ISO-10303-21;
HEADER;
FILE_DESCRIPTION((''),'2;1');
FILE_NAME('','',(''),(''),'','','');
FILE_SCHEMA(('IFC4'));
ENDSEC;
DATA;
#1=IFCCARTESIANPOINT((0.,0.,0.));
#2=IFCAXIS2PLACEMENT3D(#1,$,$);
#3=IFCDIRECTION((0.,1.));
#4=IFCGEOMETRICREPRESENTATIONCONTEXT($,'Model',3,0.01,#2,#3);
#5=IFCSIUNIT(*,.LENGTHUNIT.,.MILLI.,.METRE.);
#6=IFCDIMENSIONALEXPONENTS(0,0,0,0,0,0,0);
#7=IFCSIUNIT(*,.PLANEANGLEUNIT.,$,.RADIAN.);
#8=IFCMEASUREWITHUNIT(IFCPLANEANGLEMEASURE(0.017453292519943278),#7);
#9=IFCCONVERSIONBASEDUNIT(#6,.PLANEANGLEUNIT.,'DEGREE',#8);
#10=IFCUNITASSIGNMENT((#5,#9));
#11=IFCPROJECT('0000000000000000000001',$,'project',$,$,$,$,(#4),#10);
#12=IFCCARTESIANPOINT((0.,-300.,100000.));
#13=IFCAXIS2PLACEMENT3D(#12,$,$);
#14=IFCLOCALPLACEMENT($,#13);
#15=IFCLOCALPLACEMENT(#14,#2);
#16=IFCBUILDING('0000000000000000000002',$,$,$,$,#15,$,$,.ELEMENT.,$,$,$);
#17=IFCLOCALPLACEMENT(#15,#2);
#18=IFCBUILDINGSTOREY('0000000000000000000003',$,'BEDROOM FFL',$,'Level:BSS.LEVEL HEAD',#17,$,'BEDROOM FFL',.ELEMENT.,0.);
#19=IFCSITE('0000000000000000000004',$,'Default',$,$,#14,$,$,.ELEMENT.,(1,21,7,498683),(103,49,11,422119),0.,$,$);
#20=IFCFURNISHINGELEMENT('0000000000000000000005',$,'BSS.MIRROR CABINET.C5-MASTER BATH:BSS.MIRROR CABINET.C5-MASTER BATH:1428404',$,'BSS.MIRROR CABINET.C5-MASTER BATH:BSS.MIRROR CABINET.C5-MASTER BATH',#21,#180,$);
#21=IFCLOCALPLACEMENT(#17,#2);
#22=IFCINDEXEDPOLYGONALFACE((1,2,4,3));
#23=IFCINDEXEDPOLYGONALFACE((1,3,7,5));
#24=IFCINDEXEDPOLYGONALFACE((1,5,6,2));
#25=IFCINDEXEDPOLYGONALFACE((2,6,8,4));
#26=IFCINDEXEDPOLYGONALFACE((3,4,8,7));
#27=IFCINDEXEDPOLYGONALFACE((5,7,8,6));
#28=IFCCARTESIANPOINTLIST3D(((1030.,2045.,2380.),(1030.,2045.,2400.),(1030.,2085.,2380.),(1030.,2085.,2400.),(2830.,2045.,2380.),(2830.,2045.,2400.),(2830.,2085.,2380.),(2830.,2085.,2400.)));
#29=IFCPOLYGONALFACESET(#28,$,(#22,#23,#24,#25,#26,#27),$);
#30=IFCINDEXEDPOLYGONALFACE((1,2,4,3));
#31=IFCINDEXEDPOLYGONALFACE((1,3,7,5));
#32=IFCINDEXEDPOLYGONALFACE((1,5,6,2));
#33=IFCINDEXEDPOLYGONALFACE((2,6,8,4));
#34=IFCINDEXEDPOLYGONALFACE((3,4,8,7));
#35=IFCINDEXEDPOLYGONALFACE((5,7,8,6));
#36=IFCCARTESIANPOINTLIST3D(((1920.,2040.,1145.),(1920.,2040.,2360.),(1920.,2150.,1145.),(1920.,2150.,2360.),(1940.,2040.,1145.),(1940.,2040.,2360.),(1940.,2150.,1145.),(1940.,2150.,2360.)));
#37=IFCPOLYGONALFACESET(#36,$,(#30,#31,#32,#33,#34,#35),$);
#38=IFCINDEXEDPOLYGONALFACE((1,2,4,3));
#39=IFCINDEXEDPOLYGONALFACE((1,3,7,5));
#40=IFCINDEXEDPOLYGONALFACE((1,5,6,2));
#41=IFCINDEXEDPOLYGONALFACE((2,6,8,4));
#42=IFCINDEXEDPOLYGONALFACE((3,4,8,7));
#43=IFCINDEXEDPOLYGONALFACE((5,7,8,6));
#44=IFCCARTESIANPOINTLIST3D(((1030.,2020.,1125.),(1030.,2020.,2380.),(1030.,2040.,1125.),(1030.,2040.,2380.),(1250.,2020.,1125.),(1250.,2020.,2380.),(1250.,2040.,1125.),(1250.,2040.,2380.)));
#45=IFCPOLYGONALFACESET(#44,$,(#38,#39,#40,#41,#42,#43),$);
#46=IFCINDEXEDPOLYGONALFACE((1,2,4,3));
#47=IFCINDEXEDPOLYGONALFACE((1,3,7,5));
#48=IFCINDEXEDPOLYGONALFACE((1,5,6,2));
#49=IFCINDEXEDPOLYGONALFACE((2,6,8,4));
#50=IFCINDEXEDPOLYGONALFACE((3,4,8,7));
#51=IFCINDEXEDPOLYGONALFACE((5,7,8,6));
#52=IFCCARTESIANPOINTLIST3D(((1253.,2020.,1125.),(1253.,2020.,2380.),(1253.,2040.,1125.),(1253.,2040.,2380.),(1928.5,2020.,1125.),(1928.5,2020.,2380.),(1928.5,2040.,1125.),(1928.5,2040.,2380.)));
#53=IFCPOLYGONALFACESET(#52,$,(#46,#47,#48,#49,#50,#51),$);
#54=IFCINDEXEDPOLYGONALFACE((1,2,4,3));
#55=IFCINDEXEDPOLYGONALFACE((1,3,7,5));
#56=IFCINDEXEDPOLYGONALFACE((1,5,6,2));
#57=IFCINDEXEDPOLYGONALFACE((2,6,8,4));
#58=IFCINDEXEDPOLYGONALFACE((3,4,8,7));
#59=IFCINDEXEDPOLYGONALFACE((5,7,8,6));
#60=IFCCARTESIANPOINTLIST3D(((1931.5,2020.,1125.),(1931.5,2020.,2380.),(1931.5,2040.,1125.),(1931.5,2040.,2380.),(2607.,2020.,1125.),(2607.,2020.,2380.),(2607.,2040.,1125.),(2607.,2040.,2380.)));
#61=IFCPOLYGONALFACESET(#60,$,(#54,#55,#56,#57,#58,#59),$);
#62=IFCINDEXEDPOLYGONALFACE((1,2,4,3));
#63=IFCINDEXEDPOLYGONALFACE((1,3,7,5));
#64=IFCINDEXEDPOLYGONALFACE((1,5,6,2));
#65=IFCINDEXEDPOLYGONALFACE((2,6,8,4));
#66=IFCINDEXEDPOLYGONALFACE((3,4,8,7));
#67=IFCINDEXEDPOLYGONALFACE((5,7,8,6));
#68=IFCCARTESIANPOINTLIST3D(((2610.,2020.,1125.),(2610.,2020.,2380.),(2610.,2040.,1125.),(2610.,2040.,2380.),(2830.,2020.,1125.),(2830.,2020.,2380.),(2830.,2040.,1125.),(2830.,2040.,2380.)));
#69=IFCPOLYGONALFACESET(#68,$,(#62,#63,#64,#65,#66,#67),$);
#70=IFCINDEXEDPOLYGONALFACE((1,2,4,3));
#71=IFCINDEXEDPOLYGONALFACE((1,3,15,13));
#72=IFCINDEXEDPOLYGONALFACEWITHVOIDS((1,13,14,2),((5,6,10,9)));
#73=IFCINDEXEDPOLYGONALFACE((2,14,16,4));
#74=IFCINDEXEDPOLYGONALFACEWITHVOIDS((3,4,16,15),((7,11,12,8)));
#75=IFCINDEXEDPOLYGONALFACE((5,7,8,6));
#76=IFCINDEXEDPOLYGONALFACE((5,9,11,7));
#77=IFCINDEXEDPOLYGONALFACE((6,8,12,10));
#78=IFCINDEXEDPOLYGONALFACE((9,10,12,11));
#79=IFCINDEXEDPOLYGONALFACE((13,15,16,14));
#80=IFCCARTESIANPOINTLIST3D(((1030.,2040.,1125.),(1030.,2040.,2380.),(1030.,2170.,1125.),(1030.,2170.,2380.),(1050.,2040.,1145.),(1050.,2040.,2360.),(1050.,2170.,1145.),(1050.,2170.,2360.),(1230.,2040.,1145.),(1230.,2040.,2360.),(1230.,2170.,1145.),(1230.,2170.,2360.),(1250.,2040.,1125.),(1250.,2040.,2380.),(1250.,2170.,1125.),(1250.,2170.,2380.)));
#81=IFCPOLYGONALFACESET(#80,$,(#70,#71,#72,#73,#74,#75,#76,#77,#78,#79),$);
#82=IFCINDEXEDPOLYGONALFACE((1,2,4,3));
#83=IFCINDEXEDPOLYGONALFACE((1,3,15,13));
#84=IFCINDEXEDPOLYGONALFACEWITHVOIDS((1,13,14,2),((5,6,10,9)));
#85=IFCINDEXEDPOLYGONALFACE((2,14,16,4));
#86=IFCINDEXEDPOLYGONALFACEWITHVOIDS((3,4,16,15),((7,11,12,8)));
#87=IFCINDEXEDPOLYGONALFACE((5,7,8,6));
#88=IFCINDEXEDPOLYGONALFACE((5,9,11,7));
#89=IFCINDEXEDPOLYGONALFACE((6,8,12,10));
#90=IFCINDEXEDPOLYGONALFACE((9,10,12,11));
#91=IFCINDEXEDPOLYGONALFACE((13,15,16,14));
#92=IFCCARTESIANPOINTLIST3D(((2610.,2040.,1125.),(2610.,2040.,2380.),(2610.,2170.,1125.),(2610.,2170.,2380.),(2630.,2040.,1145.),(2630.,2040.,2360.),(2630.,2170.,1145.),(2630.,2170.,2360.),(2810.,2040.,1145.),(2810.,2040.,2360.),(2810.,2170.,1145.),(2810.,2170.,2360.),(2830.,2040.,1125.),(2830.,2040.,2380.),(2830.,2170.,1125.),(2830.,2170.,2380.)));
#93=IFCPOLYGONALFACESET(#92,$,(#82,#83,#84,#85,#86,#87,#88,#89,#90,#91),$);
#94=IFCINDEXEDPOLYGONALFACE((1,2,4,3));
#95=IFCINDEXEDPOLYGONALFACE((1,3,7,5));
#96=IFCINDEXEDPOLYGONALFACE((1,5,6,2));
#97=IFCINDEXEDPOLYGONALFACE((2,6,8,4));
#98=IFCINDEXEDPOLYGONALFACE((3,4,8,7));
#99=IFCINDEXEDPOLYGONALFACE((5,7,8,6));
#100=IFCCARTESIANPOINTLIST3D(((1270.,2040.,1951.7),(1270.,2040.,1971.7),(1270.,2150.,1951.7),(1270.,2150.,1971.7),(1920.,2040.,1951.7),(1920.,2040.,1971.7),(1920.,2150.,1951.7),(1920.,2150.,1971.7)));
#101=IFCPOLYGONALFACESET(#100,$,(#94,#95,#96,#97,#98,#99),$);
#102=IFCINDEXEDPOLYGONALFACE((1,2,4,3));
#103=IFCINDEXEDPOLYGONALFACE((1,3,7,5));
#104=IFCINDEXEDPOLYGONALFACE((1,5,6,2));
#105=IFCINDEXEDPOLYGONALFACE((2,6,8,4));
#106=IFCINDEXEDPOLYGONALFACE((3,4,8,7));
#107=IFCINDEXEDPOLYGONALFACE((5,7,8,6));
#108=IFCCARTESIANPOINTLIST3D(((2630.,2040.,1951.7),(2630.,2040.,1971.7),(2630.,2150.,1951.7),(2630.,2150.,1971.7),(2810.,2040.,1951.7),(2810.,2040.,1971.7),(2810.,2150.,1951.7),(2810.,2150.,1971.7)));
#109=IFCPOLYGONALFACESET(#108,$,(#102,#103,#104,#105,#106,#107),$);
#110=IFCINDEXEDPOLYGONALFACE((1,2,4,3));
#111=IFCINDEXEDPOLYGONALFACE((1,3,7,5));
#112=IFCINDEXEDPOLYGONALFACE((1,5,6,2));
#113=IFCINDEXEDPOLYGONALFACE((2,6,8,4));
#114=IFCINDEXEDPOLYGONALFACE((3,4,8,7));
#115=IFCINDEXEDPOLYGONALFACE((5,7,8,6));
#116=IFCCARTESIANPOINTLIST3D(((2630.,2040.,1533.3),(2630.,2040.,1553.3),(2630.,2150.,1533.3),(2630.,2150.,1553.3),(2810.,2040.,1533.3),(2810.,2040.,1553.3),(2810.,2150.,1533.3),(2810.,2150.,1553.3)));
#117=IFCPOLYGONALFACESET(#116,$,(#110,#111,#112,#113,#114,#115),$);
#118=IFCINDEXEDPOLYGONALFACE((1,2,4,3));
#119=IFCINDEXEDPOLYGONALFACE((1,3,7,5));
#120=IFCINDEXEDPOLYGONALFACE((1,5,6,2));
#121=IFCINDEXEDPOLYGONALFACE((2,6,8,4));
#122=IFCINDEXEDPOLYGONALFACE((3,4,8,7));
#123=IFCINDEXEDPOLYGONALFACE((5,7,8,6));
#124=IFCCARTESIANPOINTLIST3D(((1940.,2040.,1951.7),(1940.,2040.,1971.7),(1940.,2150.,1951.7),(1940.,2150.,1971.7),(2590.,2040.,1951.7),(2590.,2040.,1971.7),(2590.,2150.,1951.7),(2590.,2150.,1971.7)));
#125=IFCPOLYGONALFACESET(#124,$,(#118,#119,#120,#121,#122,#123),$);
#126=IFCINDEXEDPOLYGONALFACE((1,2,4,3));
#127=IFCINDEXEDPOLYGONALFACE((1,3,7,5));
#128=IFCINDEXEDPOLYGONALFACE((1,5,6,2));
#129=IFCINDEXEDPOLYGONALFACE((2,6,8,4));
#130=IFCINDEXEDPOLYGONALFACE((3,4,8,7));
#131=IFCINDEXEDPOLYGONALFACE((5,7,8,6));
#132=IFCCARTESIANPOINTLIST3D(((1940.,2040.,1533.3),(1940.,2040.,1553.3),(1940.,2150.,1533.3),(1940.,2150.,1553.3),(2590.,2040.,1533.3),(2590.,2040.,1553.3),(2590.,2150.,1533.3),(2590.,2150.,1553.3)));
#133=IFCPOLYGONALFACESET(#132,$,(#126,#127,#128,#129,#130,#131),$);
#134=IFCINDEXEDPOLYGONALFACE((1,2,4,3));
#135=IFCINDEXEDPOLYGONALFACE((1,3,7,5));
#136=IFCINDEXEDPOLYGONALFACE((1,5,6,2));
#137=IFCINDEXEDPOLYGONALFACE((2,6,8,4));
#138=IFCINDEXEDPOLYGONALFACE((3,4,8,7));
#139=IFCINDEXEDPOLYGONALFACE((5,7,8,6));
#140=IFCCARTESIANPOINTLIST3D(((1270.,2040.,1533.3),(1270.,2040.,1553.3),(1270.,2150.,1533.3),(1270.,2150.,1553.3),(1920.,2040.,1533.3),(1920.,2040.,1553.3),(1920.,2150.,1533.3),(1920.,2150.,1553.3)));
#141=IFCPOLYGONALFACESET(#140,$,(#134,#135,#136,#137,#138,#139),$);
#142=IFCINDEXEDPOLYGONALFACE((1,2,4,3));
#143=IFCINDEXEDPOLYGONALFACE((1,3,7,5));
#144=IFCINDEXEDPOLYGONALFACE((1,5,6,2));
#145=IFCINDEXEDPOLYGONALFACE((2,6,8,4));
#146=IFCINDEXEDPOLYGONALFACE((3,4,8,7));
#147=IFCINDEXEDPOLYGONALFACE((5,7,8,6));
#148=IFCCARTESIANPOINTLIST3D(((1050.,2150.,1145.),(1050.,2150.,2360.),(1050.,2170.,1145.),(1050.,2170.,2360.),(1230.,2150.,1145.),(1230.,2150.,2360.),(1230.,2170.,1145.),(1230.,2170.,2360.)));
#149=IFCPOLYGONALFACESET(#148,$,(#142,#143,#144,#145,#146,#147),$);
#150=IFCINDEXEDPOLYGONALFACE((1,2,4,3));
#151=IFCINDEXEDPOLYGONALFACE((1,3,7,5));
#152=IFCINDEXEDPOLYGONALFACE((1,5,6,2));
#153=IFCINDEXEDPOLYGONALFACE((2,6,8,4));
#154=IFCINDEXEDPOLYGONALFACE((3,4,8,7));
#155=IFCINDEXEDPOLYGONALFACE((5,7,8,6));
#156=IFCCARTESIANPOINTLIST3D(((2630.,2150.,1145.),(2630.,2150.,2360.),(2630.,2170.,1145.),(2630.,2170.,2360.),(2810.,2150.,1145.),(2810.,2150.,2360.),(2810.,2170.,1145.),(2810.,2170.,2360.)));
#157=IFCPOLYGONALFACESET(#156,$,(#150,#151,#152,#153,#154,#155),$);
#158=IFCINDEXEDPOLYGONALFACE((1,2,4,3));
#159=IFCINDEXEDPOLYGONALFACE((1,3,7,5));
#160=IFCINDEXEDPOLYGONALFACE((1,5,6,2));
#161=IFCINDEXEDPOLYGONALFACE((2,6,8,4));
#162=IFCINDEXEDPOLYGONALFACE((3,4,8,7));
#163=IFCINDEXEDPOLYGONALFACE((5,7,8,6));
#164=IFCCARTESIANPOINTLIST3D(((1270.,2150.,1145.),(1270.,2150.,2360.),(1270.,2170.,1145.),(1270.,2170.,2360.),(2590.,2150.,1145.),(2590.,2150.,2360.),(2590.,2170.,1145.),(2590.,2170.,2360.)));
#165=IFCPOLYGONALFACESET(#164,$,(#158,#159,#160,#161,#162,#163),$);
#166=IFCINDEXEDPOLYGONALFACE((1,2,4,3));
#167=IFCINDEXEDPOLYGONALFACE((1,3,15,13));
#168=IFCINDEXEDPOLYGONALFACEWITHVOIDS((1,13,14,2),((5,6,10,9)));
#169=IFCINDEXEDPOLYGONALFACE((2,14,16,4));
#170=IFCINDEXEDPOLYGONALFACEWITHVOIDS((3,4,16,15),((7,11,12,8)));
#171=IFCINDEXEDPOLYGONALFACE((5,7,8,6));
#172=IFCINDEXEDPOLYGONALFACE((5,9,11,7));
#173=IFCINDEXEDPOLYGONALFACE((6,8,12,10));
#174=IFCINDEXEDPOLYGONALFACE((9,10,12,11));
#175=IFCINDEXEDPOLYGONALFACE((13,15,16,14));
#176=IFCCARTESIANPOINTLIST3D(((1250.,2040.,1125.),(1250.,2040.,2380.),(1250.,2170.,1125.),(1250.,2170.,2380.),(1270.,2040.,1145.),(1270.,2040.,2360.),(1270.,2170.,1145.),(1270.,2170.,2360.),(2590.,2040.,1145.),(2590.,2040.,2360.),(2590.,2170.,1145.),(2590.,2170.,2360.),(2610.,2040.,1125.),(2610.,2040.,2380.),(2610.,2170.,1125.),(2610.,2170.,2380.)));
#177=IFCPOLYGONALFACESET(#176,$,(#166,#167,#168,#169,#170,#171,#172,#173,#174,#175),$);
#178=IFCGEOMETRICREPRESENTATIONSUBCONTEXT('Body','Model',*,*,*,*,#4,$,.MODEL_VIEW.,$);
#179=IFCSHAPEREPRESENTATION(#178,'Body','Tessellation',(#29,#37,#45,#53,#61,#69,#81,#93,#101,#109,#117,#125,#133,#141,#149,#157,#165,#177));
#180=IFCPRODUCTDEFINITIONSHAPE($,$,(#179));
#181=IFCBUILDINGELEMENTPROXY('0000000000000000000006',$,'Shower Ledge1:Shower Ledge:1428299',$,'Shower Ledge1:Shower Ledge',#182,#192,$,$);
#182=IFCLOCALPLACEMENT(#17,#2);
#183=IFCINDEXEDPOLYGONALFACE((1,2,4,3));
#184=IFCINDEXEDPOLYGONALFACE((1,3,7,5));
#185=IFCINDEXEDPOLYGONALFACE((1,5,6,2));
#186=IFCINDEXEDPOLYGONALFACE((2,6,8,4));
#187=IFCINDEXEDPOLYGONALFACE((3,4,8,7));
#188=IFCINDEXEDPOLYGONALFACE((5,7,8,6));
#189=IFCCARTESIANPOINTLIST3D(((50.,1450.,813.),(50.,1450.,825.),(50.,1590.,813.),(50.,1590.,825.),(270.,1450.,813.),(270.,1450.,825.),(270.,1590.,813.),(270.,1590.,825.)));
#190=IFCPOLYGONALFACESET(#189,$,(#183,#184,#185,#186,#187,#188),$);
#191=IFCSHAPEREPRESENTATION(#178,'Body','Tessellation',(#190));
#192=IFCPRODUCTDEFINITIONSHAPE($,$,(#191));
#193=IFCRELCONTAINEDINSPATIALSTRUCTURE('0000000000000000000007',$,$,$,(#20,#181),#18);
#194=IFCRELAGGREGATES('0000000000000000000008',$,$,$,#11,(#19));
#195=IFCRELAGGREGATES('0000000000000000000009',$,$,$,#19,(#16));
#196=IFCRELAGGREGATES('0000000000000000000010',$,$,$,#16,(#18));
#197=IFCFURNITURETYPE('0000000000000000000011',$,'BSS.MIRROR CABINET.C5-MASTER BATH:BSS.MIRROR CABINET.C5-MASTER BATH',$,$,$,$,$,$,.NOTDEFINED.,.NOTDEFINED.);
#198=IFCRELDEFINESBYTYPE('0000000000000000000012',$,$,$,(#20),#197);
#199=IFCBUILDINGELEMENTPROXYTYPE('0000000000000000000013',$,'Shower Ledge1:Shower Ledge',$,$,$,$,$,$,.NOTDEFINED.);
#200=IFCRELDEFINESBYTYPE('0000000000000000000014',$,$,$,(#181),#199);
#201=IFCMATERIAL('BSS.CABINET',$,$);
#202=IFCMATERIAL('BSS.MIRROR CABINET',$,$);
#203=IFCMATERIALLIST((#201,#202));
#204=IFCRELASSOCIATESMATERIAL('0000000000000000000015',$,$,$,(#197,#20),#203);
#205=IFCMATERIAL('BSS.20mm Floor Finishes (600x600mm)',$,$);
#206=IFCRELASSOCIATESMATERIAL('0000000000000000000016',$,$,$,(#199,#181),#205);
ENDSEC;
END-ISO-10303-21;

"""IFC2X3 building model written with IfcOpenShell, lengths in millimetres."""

from ifc_helpers import new_model, entity, si_unit, converted_unit, direction, frame, frame_2d, origin, origin_2d_with_axis, place, context, subcontext, project, spatial, polyline, rectangle, outline, extrude, source, transform, mapped, material, material_list, type_object, type_shapes, element, save


model = new_model("IFC2X3")

# Units and contexts
model_context = context("Model", 3, precision=0.01, world=origin(), true_north=direction((0.0, 1.0)))
body_context = subcontext(model_context, "Body", "Model", "MODEL_VIEW")
ifc_project = project(units=[si_unit("LENGTHUNIT", "METRE", prefix="MILLI"), converted_unit("PLANEANGLEUNIT", "DEGREE", entity("IfcPlaneAngleMeasure", 0.017453292519943278), si_unit("PLANEANGLEUNIT", "RADIAN"), dimensions=[0, 0, 0, 0, 0, 0, 0])], contexts=[model_context])

# Site, building, storey
site_placement = place(None, frame((0.0, -300.0, 100000.0)))
site = spatial("IfcSite", under=ifc_project, at=site_placement, Name="Default", CompositionType="ELEMENT", RefLatitude=(1, 21, 7, 498683), RefLongitude=(103, 49, 11, 422119), RefElevation=0.0)
building_placement = place(site_placement, origin())
building = spatial("IfcBuilding", under=site, at=building_placement, CompositionType="ELEMENT")
storey_placement = place(building_placement, origin())
storey = spatial("IfcBuildingStorey", under=building, at=storey_placement, Name="BEDROOM FFL", ObjectType="Level:BSS.LEVEL HEAD", LongName="BEDROOM FFL", CompositionType="ELEMENT", Elevation=0.0)

# Furnishing element
ifc_material_1 = material(Name="BSS.CABINET")
ifc_material_2 = material(Name="BSS.MIRROR CABINET")
ifc_material_list = material_list([ifc_material_1, ifc_material_2])
furniture_type = type_object("IfcFurnitureType", Name="BSS.MIRROR CABINET.C5-MASTER BATH:BSS.MIRROR CABINET.C5-MASTER BATH", AssemblyPlace="NOTDEFINED", material=ifc_material_list)
shared_shape_1 = source(origin(), body_context, "Body", "SweptSolid", [
    extrude(rectangle(XDim=40.0, YDim=1800.0, at=frame_2d((0.0, 0.0), x_axis=(1.0, 0.0))), frame((0.0, 105.0, 1255.0), z_axis=(0.0, 0.0, 1.0), x_axis=(0.0, 1.0, 0.0)), (0.0, 0.0, 1.0), 20.0),
    extrude(rectangle(XDim=20.0, YDim=110.0, at=frame_2d((0.0, 0.0), x_axis=(1.0, 0.0))), frame((0.0, 75.0, 20.0), z_axis=(0.0, 0.0, 1.0), x_axis=(-1.0, 0.0, 0.0)), (0.0, 0.0, 1.0), 1215.0),
    extrude(rectangle(XDim=220.0, YDim=20.0, at=frame_2d((0.0, 0.0), x_axis=(1.0, 0.0))), frame((790.0, 140.0, 0.0), z_axis=(0.0, 0.0, 1.0), x_axis=(-1.0, 0.0, 0.0)), (0.0, 0.0, 1.0), 1255.0),
    extrude(rectangle(XDim=675.5, YDim=20.0, at=frame_2d((0.0, 0.0), x_axis=(1.0, 0.0))), frame((339.2, 140.0, 0.0), z_axis=(0.0, 0.0, 1.0), x_axis=(-1.0, 0.0, 0.0)), (0.0, 0.0, 1.0), 1255.0),
    extrude(rectangle(XDim=675.5, YDim=20.0, at=frame_2d((0.0, 0.0), x_axis=(1.0, 0.0))), frame((-339.3, 140.0, 0.0), z_axis=(0.0, 0.0, 1.0), x_axis=(-1.0, 0.0, 0.0)), (0.0, 0.0, 1.0), 1255.0),
    extrude(rectangle(XDim=220.0, YDim=20.0, at=frame_2d((0.0, 0.0), x_axis=(1.0, 0.0))), frame((-790.0, 140.0, 0.0), z_axis=(0.0, 0.0, 1.0), x_axis=(-1.0, 0.0, 0.0)), (0.0, 0.0, 1.0), 1255.0),
    extrude(outline(polyline([(-627.5, -110.0), (627.5, -110.0), (627.5, 110.0), (-627.5, 110.0), (-627.5, -110.0)]), holes=[polyline([(607.5, 90.0), (607.5, -90.0), (-607.5, -90.0), (-607.5, 90.0), (607.5, 90.0)])]), frame((790.0, 0.0, 627.5), z_axis=(0.0, 1.0, 0.0), x_axis=(0.0, 0.0, -1.0)), (0.0, 0.0, 1.0), 130.0),
    extrude(outline(polyline([(-627.5, -110.0), (627.5, -110.0), (627.5, 110.0), (-627.5, 110.0), (-627.5, -110.0)]), holes=[polyline([(607.5, 90.0), (607.5, -90.0), (-607.5, -90.0), (-607.5, 90.0), (607.5, 90.0)])]), frame((-790.0, 0.0, 627.5), z_axis=(0.0, 1.0, 0.0), x_axis=(0.0, 0.0, -1.0)), (0.0, 0.0, 1.0), 130.0),
    extrude(rectangle(XDim=650.0, YDim=110.0, at=origin_2d_with_axis()), frame((335.0, 75.0, 826.7), z_axis=(0.0, 0.0, 1.0), x_axis=(-1.0, 0.0, 0.0)), (0.0, 0.0, 1.0), 20.0),
    extrude(rectangle(XDim=180.0, YDim=110.0, at=origin_2d_with_axis()), frame((-790.0, 75.0, 826.7), z_axis=(0.0, 0.0, 1.0), x_axis=(-1.0, 0.0, 0.0)), (0.0, 0.0, 1.0), 20.0),
    extrude(rectangle(XDim=180.0, YDim=110.0, at=origin_2d_with_axis()), frame((-790.0, 75.0, 408.3), z_axis=(0.0, 0.0, 1.0), x_axis=(-1.0, 0.0, 0.0)), (0.0, 0.0, 1.0), 20.0),
    extrude(rectangle(XDim=650.0, YDim=110.0, at=origin_2d_with_axis()), frame((-335.0, 75.0, 826.7), z_axis=(0.0, 0.0, 1.0), x_axis=(-1.0, 0.0, 0.0)), (0.0, 0.0, 1.0), 20.0),
    extrude(rectangle(XDim=650.0, YDim=110.0, at=frame_2d((0.0, 0.0), x_axis=(1.0, 0.0))), frame((-335.0, 75.0, 408.3), z_axis=(0.0, 0.0, 1.0), x_axis=(-1.0, 0.0, 0.0)), (0.0, 0.0, 1.0), 20.0),
    extrude(rectangle(XDim=650.0, YDim=110.0, at=origin_2d_with_axis()), frame((335.0, 75.0, 408.3), z_axis=(0.0, 0.0, 1.0), x_axis=(-1.0, 0.0, 0.0)), (0.0, 0.0, 1.0), 20.0),
    extrude(rectangle(XDim=180.0, YDim=20.0, at=origin_2d_with_axis()), frame((790.0, 10.0, 20.0), z_axis=(0.0, 0.0, 1.0), x_axis=(-1.0, 0.0, 0.0)), (0.0, 0.0, 1.0), 1215.0),
    extrude(rectangle(XDim=180.0, YDim=20.0, at=origin_2d_with_axis()), frame((-790.0, 10.0, 20.0), z_axis=(0.0, 0.0, 1.0), x_axis=(-1.0, 0.0, 0.0)), (0.0, 0.0, 1.0), 1215.0),
    extrude(rectangle(XDim=1320.0, YDim=20.0, at=origin_2d_with_axis()), frame((0.0, 10.0, 20.0), z_axis=(0.0, 0.0, 1.0), x_axis=(-1.0, 0.0, 0.0)), (0.0, 0.0, 1.0), 1215.0),
    extrude(outline(polyline([(-680.0, -627.5), (680.0, -627.5), (680.0, 627.5), (-680.0, 627.5), (-680.0, -627.5)]), holes=[polyline([(660.0, 607.5), (660.0, -607.5), (-660.0, -607.5), (-660.0, 607.5), (660.0, 607.5)])]), frame((0.0, 0.0, 627.5), z_axis=(0.0, 1.0, 0.0), x_axis=(-1.0, 0.0, 0.0)), (0.0, 0.0, 1.0), 130.0),
])
type_shapes(furniture_type, [shared_shape_1])
furnishing_placement = place(storey_placement, frame((1930.0, 2170.0, 1125.0), z_axis=(0.0, 0.0, 1.0), x_axis=(-1.0, 0.0, 0.0)))
element("IfcFurnishingElement", 1, at=furnishing_placement, inside=storey, type_object=furniture_type, material=ifc_material_list, Name="BSS.MIRROR CABINET.C5-MASTER BATH:BSS.MIRROR CABINET.C5-MASTER BATH:1428404", ObjectType="BSS.MIRROR CABINET.C5-MASTER BATH:BSS.MIRROR CABINET.C5-MASTER BATH", context=body_context, shape_type="MappedRepresentation", body=[
    mapped(shared_shape_1, transform((0.0, 0.0, 0.0), scale=1.0)),
])

# Building element proxy
ifc_material_3 = material(Name="BSS.20mm Floor Finishes (600x600mm)")
building_element_proxy_type = type_object("IfcBuildingElementProxyType", Name="Shower Ledge1:Shower Ledge", PredefinedType="NOTDEFINED", material=ifc_material_3)
shared_shape_2 = source(origin(), body_context, "Body", "SweptSolid", [
    extrude(rectangle(XDim=220.0, YDim=140.0, at=origin_2d_with_axis()), frame((160.0, 1520.0, 813.0), z_axis=(0.0, 0.0, 1.0), x_axis=(-1.0, 0.0, 0.0)), (0.0, 0.0, 1.0), 12.0),
])
type_shapes(building_element_proxy_type, [shared_shape_2])
proxy_placement = place(storey_placement, origin())
element("IfcBuildingElementProxy", 2, at=proxy_placement, inside=storey, type_object=building_element_proxy_type, material=ifc_material_3, Name="Shower Ledge1:Shower Ledge:1428299", ObjectType="Shower Ledge1:Shower Ledge", context=body_context, shape_type="MappedRepresentation", body=[
    mapped(shared_shape_2, transform((0.0, 0.0, 0.0), scale=1.0)),
])

save(model, "model.ifc")
